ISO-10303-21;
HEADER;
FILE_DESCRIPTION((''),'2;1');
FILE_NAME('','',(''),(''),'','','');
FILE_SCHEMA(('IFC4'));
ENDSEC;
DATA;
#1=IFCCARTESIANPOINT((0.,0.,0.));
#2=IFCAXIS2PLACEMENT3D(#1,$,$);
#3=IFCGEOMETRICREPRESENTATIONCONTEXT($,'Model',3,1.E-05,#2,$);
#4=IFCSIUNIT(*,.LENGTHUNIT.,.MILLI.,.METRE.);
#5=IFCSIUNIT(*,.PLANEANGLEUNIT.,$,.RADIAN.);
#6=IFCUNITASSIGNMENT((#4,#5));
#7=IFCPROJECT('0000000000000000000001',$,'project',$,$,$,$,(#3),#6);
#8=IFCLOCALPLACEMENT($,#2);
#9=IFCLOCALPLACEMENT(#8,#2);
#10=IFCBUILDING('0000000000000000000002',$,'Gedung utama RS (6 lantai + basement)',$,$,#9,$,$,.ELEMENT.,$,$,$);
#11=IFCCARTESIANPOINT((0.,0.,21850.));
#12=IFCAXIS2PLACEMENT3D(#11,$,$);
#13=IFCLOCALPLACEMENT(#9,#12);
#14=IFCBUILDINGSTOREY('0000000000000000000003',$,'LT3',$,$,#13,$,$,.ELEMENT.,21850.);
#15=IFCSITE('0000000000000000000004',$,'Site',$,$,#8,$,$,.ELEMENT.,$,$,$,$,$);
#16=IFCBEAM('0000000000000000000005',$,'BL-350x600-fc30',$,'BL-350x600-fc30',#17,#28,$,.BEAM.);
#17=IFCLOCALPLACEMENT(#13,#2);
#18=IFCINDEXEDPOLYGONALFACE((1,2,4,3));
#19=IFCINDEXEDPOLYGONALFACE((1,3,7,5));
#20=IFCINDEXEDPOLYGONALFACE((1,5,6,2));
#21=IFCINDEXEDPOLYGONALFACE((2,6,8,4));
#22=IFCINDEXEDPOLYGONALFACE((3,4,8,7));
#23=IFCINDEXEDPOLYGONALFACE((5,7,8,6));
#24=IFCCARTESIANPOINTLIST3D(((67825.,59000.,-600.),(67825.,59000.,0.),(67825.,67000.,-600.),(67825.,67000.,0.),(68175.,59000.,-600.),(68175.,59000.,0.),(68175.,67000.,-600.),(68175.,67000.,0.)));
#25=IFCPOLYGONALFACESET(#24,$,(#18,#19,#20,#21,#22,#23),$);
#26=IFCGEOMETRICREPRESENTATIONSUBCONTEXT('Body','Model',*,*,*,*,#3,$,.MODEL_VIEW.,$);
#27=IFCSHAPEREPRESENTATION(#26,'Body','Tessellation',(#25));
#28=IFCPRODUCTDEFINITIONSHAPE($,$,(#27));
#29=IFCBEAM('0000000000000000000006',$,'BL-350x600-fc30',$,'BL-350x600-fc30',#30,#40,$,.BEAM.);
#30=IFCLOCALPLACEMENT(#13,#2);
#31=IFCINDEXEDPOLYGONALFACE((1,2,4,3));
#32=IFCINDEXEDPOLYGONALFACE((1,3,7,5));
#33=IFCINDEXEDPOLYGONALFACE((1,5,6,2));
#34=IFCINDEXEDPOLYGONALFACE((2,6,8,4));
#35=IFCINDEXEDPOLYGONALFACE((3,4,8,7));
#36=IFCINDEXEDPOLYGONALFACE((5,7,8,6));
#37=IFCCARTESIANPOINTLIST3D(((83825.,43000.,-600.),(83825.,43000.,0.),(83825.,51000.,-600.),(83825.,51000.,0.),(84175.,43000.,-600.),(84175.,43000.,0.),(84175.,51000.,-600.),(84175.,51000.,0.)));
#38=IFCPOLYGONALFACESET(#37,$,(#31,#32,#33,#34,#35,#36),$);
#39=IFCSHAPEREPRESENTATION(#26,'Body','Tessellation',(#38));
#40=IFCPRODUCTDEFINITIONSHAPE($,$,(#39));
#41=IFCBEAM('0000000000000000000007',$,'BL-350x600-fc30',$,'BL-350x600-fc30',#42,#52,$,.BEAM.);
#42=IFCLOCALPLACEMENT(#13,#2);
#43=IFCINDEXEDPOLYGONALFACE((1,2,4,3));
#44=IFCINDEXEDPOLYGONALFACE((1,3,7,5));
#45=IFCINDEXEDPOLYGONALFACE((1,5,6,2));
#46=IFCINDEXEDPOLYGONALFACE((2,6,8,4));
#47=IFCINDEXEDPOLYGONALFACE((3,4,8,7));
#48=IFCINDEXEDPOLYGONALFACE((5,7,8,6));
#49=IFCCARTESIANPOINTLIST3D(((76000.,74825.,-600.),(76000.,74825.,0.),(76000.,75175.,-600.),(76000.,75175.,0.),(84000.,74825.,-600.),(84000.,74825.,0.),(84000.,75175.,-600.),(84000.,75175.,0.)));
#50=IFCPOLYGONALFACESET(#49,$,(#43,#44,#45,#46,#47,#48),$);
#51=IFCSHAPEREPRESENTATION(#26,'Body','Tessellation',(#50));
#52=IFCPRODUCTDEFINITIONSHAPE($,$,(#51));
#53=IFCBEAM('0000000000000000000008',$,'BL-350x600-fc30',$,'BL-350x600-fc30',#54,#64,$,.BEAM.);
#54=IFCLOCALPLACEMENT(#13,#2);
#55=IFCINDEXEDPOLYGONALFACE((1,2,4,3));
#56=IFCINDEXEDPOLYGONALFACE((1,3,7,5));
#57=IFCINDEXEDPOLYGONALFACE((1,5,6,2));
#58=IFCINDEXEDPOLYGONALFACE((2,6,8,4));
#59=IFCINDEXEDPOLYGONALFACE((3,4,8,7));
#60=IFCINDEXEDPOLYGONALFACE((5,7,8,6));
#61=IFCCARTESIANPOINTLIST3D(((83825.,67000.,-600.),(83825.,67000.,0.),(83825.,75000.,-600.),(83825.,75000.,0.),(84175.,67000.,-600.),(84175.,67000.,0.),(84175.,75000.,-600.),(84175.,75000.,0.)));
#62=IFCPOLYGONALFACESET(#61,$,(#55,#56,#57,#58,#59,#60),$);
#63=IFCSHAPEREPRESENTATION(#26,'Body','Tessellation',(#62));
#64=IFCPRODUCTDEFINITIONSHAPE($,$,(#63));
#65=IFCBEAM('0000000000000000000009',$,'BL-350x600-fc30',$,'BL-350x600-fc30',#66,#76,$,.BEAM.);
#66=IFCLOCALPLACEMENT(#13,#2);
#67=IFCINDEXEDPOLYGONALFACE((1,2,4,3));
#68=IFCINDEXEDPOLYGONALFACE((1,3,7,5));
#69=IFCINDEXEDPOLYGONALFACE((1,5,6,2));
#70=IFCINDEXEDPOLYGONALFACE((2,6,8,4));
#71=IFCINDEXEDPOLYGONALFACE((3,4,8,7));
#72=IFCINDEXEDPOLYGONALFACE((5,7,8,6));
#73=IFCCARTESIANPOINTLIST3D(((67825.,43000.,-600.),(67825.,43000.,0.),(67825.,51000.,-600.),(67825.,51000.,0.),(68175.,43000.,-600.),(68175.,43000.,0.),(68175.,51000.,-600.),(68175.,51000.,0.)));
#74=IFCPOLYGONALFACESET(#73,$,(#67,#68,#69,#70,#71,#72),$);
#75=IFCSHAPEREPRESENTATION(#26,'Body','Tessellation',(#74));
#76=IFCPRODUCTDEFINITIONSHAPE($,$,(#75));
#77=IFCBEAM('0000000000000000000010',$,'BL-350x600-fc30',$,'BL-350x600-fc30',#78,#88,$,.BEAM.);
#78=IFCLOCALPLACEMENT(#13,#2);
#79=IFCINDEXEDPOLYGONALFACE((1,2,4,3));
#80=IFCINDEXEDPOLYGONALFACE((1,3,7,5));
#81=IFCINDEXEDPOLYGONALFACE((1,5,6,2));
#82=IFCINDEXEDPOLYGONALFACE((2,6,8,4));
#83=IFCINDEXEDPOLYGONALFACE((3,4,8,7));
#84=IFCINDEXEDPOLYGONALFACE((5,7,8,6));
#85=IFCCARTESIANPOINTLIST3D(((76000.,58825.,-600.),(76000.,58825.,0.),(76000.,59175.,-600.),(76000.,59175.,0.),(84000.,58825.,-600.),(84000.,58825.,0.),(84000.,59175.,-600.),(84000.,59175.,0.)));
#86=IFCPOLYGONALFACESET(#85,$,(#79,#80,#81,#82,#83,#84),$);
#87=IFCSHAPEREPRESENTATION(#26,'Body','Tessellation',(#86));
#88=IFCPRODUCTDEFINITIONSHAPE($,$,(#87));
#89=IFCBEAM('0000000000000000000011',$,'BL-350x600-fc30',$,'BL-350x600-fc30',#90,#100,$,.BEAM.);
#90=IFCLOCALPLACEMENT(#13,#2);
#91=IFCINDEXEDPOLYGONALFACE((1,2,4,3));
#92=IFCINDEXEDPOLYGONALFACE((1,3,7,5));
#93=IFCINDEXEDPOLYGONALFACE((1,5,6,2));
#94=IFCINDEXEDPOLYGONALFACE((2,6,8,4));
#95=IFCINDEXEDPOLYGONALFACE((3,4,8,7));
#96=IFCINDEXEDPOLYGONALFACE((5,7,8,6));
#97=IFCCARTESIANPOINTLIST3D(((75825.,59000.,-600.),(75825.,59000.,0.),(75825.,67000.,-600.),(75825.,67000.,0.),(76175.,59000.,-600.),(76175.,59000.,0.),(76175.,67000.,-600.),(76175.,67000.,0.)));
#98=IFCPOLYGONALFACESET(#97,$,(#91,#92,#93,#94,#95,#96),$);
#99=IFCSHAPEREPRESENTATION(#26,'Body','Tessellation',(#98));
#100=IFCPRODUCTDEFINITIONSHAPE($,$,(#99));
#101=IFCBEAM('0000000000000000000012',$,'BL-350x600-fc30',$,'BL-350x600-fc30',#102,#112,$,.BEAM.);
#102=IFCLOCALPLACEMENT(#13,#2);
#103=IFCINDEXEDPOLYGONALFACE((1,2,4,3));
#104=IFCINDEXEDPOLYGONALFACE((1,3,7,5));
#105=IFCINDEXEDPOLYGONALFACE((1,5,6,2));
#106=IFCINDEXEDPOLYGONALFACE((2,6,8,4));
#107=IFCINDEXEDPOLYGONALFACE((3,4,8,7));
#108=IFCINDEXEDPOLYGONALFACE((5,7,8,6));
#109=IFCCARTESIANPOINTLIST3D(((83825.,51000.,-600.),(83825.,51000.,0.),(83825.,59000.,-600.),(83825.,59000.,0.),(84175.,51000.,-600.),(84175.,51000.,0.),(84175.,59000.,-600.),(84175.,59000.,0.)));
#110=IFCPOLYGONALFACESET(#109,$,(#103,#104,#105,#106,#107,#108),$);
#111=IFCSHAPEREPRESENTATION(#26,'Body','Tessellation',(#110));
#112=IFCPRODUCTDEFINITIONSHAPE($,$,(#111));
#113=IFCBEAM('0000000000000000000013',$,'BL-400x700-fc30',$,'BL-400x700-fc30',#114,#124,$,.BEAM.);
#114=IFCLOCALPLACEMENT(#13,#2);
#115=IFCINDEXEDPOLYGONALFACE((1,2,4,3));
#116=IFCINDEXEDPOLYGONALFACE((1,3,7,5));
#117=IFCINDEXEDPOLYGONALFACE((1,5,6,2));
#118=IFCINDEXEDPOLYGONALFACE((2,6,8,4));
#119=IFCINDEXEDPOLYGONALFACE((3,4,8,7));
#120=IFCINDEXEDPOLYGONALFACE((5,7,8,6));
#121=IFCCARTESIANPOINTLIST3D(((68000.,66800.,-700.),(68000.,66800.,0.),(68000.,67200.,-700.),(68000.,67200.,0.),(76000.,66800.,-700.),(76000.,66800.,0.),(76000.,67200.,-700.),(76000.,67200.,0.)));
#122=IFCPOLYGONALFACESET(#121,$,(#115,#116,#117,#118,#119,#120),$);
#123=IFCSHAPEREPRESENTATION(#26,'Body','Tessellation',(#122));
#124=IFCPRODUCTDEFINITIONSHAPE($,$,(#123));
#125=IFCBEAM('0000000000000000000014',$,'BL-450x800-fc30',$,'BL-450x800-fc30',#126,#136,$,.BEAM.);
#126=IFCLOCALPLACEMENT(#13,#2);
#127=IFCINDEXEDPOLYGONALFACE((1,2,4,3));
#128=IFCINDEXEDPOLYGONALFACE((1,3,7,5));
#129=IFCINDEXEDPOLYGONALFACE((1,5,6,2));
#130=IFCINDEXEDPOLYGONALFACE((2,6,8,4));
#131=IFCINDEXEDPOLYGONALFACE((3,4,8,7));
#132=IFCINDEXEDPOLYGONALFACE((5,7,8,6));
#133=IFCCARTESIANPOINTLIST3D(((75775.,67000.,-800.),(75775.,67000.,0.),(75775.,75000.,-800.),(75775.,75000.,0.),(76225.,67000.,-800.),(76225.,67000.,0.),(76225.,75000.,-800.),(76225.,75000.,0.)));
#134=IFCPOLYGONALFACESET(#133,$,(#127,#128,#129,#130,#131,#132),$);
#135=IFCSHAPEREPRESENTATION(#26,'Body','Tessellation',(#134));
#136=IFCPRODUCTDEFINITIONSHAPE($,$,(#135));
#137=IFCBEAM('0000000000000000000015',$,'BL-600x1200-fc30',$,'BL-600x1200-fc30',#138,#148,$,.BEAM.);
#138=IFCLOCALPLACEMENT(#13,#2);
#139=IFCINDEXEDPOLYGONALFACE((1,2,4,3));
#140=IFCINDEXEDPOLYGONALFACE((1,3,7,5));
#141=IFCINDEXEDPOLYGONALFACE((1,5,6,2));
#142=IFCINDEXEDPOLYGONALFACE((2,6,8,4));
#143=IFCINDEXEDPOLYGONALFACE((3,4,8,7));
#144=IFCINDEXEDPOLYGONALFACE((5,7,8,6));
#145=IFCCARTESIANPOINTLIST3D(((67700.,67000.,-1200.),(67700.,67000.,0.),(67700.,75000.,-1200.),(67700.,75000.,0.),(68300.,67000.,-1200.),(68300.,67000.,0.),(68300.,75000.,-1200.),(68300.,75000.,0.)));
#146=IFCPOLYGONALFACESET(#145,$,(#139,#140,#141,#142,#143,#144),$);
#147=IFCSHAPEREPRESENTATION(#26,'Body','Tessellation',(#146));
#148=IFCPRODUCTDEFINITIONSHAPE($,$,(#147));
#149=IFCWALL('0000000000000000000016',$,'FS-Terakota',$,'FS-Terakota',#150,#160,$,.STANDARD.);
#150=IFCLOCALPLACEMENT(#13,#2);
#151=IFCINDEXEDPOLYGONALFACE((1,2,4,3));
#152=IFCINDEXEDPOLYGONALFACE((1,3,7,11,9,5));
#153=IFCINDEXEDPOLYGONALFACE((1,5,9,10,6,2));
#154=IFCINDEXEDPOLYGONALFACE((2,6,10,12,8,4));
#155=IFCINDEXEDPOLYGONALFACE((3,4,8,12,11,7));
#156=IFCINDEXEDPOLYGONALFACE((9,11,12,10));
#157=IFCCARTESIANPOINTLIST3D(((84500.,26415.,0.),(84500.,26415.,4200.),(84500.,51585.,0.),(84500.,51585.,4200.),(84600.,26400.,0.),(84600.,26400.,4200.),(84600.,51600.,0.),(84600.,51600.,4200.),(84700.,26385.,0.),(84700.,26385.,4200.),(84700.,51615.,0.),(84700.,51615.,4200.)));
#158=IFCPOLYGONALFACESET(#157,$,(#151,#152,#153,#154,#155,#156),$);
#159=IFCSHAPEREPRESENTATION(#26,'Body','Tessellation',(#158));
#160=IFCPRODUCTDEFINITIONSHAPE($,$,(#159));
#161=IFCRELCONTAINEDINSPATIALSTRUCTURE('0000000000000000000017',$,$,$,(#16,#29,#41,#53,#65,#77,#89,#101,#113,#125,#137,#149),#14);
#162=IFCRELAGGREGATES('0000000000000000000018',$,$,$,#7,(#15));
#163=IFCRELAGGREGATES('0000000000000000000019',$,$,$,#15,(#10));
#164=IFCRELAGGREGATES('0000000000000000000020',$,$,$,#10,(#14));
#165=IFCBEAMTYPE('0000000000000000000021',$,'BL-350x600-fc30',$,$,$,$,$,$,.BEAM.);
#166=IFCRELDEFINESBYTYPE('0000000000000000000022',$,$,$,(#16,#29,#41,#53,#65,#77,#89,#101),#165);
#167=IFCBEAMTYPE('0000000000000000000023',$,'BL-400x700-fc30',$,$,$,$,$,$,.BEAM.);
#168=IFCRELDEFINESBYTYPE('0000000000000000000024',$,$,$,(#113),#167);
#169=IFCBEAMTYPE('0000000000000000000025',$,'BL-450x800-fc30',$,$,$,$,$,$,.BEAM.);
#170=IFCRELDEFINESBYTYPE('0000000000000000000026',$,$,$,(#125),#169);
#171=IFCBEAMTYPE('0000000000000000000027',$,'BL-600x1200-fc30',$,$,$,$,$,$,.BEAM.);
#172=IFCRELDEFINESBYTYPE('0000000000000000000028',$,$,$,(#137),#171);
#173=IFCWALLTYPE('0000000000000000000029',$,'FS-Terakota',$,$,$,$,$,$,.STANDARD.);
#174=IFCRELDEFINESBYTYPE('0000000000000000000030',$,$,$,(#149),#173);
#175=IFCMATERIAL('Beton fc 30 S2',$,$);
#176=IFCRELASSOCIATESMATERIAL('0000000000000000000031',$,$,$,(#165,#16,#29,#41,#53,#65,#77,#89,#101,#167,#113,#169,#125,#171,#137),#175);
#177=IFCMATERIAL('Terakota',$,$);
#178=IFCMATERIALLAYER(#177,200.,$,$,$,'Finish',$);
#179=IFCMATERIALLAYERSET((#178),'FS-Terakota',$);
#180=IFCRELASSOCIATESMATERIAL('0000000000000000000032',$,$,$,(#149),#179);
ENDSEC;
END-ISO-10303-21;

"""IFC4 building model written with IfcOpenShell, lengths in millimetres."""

from ifc_helpers import new_model, si_unit, frame, origin, origin_2d, place, context, subcontext, project, spatial, polyline, rectangle, outline, extrude, material, layer, layer_set, layer_usage, material_profile, profile_set, profile_usage, type_object, element, save


model = new_model("IFC4")

# Units and contexts
model_context = context("Model", 3, precision=1e-05, world=origin())
body_context = subcontext(model_context, "Body", "Model", "MODEL_VIEW")
ifc_project = project(units=[si_unit("LENGTHUNIT", "METRE", prefix="MILLI"), si_unit("PLANEANGLEUNIT", "RADIAN")], contexts=[model_context])

# Site, building, storey
site_placement = place(None, origin())
site = spatial("IfcSite", under=ifc_project, at=site_placement, Name="Site", CompositionType="ELEMENT")
building_placement = place(site_placement, origin())
building = spatial("IfcBuilding", under=site, at=building_placement, Name="Gedung utama RS (6 lantai + basement)", CompositionType="ELEMENT")
storey_placement = place(building_placement, frame((0.0, 0.0, 21850.0)))
storey = spatial("IfcBuildingStorey", under=building, at=storey_placement, Name="LT3", CompositionType="ELEMENT", Elevation=21850.0)

# Beams
ifc_material_1 = material(Name="Beton fc 30 S2")
ifc_material_profile_1 = material_profile(ifc_material_1, rectangle(XDim=350.0, YDim=600.0, at=origin_2d()), Name="BL-350x600-fc30")
ifc_profile_set_1 = profile_set([ifc_material_profile_1], Name="BL-350x600-fc30")
ifc_profile_usage_1 = profile_usage(ifc_profile_set_1, cardinal=8)
beam_type_1 = type_object("IfcBeamType", Name="BL-350x600-fc30", PredefinedType="BEAM", material=ifc_profile_set_1)
for number, where, name in (
    (1, (68000.0, 59000.0, -300.0), "BL-350x600-fc30"),
    (2, (84000.0, 43000.0, -300.0), "BL-350x600-fc30"),
):
    element("IfcBeam", number, at=place(storey_placement, frame(where)), inside=storey, type_object=beam_type_1, material=ifc_profile_usage_1, Name=name, ObjectType="BL-350x600-fc30", PredefinedType="BEAM", context=body_context, shape_type="SweptSolid", body=[
        extrude(rectangle(XDim=350.0, YDim=600.0, at=origin_2d()), frame((0.0, 0.0, 0.0), z_axis=(0.0, 1.0, 0.0), x_axis=(-1.0, 0.0, 0.0)), (0.0, 0.0, 1.0), 8000.0),
    ])
beam_1_placement = place(storey_placement, frame((76000.0, 75000.0, -300.0)))
element("IfcBeam", 3, at=beam_1_placement, inside=storey, type_object=beam_type_1, material=ifc_profile_usage_1, Name="BL-350x600-fc30", ObjectType="BL-350x600-fc30", PredefinedType="BEAM", context=body_context, shape_type="SweptSolid", body=[
    extrude(rectangle(XDim=350.0, YDim=600.0, at=origin_2d()), frame((0.0, 0.0, 0.0), z_axis=(1.0, 0.0, 0.0), x_axis=(0.0, 1.0, 0.0)), (0.0, 0.0, 1.0), 8000.0),
])
for number, where, name in (
    (4, (84000.0, 67000.0, -300.0), "BL-350x600-fc30"),
    (5, (68000.0, 43000.0, -300.0), "BL-350x600-fc30"),
):
    element("IfcBeam", number, at=place(storey_placement, frame(where)), inside=storey, type_object=beam_type_1, material=ifc_profile_usage_1, Name=name, ObjectType="BL-350x600-fc30", PredefinedType="BEAM", context=body_context, shape_type="SweptSolid", body=[
        extrude(rectangle(XDim=350.0, YDim=600.0, at=origin_2d()), frame((0.0, 0.0, 0.0), z_axis=(0.0, 1.0, 0.0), x_axis=(-1.0, 0.0, 0.0)), (0.0, 0.0, 1.0), 8000.0),
    ])
beam_2_placement = place(storey_placement, frame((76000.0, 59000.0, -300.0)))
element("IfcBeam", 6, at=beam_2_placement, inside=storey, type_object=beam_type_1, material=ifc_profile_usage_1, Name="BL-350x600-fc30", ObjectType="BL-350x600-fc30", PredefinedType="BEAM", context=body_context, shape_type="SweptSolid", body=[
    extrude(rectangle(XDim=350.0, YDim=600.0, at=origin_2d()), frame((0.0, 0.0, 0.0), z_axis=(1.0, 0.0, 0.0), x_axis=(0.0, 1.0, 0.0)), (0.0, 0.0, 1.0), 8000.0),
])
for number, where, name in (
    (7, (76000.0, 59000.0, -300.0), "BL-350x600-fc30"),
    (8, (84000.0, 51000.0, -300.0), "BL-350x600-fc30"),
):
    element("IfcBeam", number, at=place(storey_placement, frame(where)), inside=storey, type_object=beam_type_1, material=ifc_profile_usage_1, Name=name, ObjectType="BL-350x600-fc30", PredefinedType="BEAM", context=body_context, shape_type="SweptSolid", body=[
        extrude(rectangle(XDim=350.0, YDim=600.0, at=origin_2d()), frame((0.0, 0.0, 0.0), z_axis=(0.0, 1.0, 0.0), x_axis=(-1.0, 0.0, 0.0)), (0.0, 0.0, 1.0), 8000.0),
    ])
ifc_material_profile_2 = material_profile(ifc_material_1, rectangle(XDim=400.0, YDim=700.0, at=origin_2d()), Name="BL-400x700-fc30")
ifc_profile_set_2 = profile_set([ifc_material_profile_2], Name="BL-400x700-fc30")
ifc_profile_usage_2 = profile_usage(ifc_profile_set_2, cardinal=8)
beam_type_2 = type_object("IfcBeamType", Name="BL-400x700-fc30", PredefinedType="BEAM", material=ifc_profile_set_2)
beam_3_placement = place(storey_placement, frame((68000.0, 67000.0, -350.0)))
element("IfcBeam", 9, at=beam_3_placement, inside=storey, type_object=beam_type_2, material=ifc_profile_usage_2, Name="BL-400x700-fc30", ObjectType="BL-400x700-fc30", PredefinedType="BEAM", context=body_context, shape_type="SweptSolid", body=[
    extrude(rectangle(XDim=400.0, YDim=700.0, at=origin_2d()), frame((0.0, 0.0, 0.0), z_axis=(1.0, 0.0, 0.0), x_axis=(0.0, 1.0, 0.0)), (0.0, 0.0, 1.0), 8000.0),
])
ifc_material_profile_3 = material_profile(ifc_material_1, rectangle(XDim=450.0, YDim=800.0, at=origin_2d()), Name="BL-450x800-fc30")
ifc_profile_set_3 = profile_set([ifc_material_profile_3], Name="BL-450x800-fc30")
ifc_profile_usage_3 = profile_usage(ifc_profile_set_3, cardinal=8)
beam_type_3 = type_object("IfcBeamType", Name="BL-450x800-fc30", PredefinedType="BEAM", material=ifc_profile_set_3)
beam_4_placement = place(storey_placement, frame((76000.0, 67000.0, -400.0)))
element("IfcBeam", 10, at=beam_4_placement, inside=storey, type_object=beam_type_3, material=ifc_profile_usage_3, Name="BL-450x800-fc30", ObjectType="BL-450x800-fc30", PredefinedType="BEAM", context=body_context, shape_type="SweptSolid", body=[
    extrude(rectangle(XDim=450.0, YDim=800.0, at=origin_2d()), frame((0.0, 0.0, 0.0), z_axis=(0.0, 1.0, 0.0), x_axis=(-1.0, 0.0, 0.0)), (0.0, 0.0, 1.0), 8000.0),
])
ifc_material_profile_4 = material_profile(ifc_material_1, rectangle(XDim=600.0, YDim=1200.0, at=origin_2d()), Name="BL-600x1200-fc30")
ifc_profile_set_4 = profile_set([ifc_material_profile_4], Name="BL-600x1200-fc30")
ifc_profile_usage_4 = profile_usage(ifc_profile_set_4, cardinal=8)
beam_type_4 = type_object("IfcBeamType", Name="BL-600x1200-fc30", PredefinedType="BEAM", material=ifc_profile_set_4)
beam_5_placement = place(storey_placement, frame((68000.0, 67000.0, -600.0)))
element("IfcBeam", 11, at=beam_5_placement, inside=storey, type_object=beam_type_4, material=ifc_profile_usage_4, Name="BL-600x1200-fc30", ObjectType="BL-600x1200-fc30", PredefinedType="BEAM", context=body_context, shape_type="SweptSolid", body=[
    extrude(rectangle(XDim=600.0, YDim=1200.0, at=origin_2d()), frame((0.0, 0.0, 0.0), z_axis=(0.0, 1.0, 0.0), x_axis=(-1.0, 0.0, 0.0)), (0.0, 0.0, 1.0), 8000.0),
])

# Wall
ifc_material_2 = material(Name="Terakota")
ifc_layer = layer(ifc_material_2, 200.0, Category="Finish")
ifc_layer_set = layer_set([ifc_layer], Name="FS-Terakota")
ifc_layer_usage = layer_usage(ifc_layer_set, "AXIS2", "NEGATIVE", 100.0)
wall_type = type_object("IfcWallType", Name="FS-Terakota", PredefinedType="STANDARD")
wall_placement = place(storey_placement, frame((84600.0, 51600.0, 0.0), z_axis=(0.0, 0.0, 1.0), x_axis=(0.0, -1.0, 0.0)))
element("IfcWall", 12, at=wall_placement, inside=storey, type_object=wall_type, material=ifc_layer_usage, Name="FS-Terakota", ObjectType="FS-Terakota", PredefinedType="STANDARD", context=body_context, shape_type="SweptSolid", body=[
    extrude(outline(polyline([(15.0, -100.0), (0.0, 0.0), (-15.0, 100.0), (25215.0, 100.0), (25200.0, 0.0), (25185.0, -100.0), (15.0, -100.0)])), origin(), (0.0, 0.0, 1.0), 4200.0),
])

save(model, "model.ifc")
